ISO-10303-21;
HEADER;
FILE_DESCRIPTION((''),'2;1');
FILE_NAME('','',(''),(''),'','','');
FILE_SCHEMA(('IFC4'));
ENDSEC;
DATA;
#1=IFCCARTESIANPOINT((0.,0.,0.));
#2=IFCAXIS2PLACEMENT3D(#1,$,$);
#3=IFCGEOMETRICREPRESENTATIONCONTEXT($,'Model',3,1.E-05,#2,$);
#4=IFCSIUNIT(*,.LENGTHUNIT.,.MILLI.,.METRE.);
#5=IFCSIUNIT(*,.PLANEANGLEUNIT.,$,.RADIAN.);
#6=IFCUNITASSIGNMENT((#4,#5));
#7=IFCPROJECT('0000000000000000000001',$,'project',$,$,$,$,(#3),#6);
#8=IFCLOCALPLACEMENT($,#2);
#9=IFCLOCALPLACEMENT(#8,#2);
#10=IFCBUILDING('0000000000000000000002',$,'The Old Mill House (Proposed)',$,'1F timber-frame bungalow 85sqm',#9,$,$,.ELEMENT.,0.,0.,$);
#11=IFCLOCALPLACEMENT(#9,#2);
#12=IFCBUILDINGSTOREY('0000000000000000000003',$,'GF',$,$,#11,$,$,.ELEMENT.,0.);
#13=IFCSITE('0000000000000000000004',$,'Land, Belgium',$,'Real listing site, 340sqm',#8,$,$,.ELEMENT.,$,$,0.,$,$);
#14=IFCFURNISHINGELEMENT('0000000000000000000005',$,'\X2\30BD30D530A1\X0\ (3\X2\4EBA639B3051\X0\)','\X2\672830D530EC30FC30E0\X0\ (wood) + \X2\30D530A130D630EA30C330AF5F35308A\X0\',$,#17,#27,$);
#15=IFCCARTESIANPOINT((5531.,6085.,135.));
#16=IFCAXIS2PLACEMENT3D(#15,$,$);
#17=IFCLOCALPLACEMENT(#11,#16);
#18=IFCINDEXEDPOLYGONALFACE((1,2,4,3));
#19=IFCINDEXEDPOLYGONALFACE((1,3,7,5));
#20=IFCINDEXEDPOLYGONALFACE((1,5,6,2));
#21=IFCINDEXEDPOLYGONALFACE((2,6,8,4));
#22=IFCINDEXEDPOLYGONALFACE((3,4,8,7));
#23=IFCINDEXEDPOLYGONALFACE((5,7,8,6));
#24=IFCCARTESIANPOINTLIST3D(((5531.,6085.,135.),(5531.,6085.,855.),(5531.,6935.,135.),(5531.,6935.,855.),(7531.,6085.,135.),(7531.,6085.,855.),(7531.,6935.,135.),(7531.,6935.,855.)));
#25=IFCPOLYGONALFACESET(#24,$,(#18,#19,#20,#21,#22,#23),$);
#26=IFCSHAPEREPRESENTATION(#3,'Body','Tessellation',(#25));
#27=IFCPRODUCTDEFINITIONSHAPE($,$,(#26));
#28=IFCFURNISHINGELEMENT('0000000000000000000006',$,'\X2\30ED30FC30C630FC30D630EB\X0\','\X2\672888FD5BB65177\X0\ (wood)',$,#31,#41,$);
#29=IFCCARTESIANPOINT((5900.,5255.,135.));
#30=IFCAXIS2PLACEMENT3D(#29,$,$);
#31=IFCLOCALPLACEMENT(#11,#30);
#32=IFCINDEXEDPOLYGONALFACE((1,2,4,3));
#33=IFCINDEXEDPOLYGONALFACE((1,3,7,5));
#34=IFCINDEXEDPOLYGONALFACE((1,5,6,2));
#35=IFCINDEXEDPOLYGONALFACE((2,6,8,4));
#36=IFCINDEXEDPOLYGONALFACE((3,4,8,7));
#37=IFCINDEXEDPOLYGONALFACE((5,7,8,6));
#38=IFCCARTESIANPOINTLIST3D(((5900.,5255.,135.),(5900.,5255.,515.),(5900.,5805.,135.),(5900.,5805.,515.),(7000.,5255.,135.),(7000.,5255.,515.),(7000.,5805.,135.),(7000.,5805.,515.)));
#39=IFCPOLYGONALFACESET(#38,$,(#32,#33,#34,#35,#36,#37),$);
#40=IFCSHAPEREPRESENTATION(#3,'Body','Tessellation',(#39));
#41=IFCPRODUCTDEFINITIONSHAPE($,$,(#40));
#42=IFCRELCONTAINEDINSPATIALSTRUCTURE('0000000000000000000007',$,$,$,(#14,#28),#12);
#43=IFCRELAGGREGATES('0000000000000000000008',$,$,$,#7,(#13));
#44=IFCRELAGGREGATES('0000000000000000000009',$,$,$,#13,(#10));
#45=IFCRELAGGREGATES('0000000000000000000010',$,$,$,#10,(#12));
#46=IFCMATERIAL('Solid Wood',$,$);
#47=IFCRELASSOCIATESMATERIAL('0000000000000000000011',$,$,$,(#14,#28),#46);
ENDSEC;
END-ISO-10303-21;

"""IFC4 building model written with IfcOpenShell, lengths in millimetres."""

from ifc_helpers import new_model, si_unit, frame, frame_2d, origin, place, context, project, spatial, rectangle, extrude, material, element, save


model = new_model("IFC4")

# Units and contexts
model_context = context("Model", 3, precision=1e-05, world=origin())
ifc_project = project(units=[si_unit("LENGTHUNIT", "METRE", prefix="MILLI"), si_unit("PLANEANGLEUNIT", "RADIAN")], contexts=[model_context])

# Site, building, storey
site_placement = place(None, origin())
site = spatial("IfcSite", under=ifc_project, at=site_placement, Name="Land, Belgium", ObjectType="Real listing site, 340sqm", CompositionType="ELEMENT", RefElevation=0.0)
building_placement = place(site_placement, origin())
building = spatial("IfcBuilding", under=site, at=building_placement, Name="The Old Mill House (Proposed)", ObjectType="1F timber-frame bungalow 85sqm", CompositionType="ELEMENT", ElevationOfRefHeight=0.0, ElevationOfTerrain=0.0)
storey_placement = place(building_placement, origin())
storey = spatial("IfcBuildingStorey", under=building, at=storey_placement, Name="GF", CompositionType="ELEMENT", Elevation=0.0)

# Shared definitions
ifc_material_1 = material(Name="Solid Wood")

# Furnishing elements
furnishing_1_placement = place(storey_placement, frame((5531.0, 6085.0, 135.0)))
element("IfcFurnishingElement", 1, at=furnishing_1_placement, inside=storey, material=ifc_material_1, Name="ソファ (3人掛け)", Description="木フレーム (wood) + ファブリック張り", context=model_context, shape_type="SweptSolid", body=[
    extrude(rectangle(XDim=2000.0, YDim=850.0, at=frame_2d((1000.0, 425.0))), frame((5531.0, 6085.0, 135.0)), (0.0, 0.0, 1.0), 720.0),
])
furnishing_2_placement = place(storey_placement, frame((5900.0, 5255.0, 135.0)))
element("IfcFurnishingElement", 2, at=furnishing_2_placement, inside=storey, material=ifc_material_1, Name="ローテーブル", Description="木製家具 (wood)", context=model_context, shape_type="SweptSolid", body=[
    extrude(rectangle(XDim=1100.0, YDim=550.0, at=frame_2d((550.0, 275.0))), frame((5900.0, 5255.0, 135.0)), (0.0, 0.0, 1.0), 380.0),
])

save(model, "model.ifc")
